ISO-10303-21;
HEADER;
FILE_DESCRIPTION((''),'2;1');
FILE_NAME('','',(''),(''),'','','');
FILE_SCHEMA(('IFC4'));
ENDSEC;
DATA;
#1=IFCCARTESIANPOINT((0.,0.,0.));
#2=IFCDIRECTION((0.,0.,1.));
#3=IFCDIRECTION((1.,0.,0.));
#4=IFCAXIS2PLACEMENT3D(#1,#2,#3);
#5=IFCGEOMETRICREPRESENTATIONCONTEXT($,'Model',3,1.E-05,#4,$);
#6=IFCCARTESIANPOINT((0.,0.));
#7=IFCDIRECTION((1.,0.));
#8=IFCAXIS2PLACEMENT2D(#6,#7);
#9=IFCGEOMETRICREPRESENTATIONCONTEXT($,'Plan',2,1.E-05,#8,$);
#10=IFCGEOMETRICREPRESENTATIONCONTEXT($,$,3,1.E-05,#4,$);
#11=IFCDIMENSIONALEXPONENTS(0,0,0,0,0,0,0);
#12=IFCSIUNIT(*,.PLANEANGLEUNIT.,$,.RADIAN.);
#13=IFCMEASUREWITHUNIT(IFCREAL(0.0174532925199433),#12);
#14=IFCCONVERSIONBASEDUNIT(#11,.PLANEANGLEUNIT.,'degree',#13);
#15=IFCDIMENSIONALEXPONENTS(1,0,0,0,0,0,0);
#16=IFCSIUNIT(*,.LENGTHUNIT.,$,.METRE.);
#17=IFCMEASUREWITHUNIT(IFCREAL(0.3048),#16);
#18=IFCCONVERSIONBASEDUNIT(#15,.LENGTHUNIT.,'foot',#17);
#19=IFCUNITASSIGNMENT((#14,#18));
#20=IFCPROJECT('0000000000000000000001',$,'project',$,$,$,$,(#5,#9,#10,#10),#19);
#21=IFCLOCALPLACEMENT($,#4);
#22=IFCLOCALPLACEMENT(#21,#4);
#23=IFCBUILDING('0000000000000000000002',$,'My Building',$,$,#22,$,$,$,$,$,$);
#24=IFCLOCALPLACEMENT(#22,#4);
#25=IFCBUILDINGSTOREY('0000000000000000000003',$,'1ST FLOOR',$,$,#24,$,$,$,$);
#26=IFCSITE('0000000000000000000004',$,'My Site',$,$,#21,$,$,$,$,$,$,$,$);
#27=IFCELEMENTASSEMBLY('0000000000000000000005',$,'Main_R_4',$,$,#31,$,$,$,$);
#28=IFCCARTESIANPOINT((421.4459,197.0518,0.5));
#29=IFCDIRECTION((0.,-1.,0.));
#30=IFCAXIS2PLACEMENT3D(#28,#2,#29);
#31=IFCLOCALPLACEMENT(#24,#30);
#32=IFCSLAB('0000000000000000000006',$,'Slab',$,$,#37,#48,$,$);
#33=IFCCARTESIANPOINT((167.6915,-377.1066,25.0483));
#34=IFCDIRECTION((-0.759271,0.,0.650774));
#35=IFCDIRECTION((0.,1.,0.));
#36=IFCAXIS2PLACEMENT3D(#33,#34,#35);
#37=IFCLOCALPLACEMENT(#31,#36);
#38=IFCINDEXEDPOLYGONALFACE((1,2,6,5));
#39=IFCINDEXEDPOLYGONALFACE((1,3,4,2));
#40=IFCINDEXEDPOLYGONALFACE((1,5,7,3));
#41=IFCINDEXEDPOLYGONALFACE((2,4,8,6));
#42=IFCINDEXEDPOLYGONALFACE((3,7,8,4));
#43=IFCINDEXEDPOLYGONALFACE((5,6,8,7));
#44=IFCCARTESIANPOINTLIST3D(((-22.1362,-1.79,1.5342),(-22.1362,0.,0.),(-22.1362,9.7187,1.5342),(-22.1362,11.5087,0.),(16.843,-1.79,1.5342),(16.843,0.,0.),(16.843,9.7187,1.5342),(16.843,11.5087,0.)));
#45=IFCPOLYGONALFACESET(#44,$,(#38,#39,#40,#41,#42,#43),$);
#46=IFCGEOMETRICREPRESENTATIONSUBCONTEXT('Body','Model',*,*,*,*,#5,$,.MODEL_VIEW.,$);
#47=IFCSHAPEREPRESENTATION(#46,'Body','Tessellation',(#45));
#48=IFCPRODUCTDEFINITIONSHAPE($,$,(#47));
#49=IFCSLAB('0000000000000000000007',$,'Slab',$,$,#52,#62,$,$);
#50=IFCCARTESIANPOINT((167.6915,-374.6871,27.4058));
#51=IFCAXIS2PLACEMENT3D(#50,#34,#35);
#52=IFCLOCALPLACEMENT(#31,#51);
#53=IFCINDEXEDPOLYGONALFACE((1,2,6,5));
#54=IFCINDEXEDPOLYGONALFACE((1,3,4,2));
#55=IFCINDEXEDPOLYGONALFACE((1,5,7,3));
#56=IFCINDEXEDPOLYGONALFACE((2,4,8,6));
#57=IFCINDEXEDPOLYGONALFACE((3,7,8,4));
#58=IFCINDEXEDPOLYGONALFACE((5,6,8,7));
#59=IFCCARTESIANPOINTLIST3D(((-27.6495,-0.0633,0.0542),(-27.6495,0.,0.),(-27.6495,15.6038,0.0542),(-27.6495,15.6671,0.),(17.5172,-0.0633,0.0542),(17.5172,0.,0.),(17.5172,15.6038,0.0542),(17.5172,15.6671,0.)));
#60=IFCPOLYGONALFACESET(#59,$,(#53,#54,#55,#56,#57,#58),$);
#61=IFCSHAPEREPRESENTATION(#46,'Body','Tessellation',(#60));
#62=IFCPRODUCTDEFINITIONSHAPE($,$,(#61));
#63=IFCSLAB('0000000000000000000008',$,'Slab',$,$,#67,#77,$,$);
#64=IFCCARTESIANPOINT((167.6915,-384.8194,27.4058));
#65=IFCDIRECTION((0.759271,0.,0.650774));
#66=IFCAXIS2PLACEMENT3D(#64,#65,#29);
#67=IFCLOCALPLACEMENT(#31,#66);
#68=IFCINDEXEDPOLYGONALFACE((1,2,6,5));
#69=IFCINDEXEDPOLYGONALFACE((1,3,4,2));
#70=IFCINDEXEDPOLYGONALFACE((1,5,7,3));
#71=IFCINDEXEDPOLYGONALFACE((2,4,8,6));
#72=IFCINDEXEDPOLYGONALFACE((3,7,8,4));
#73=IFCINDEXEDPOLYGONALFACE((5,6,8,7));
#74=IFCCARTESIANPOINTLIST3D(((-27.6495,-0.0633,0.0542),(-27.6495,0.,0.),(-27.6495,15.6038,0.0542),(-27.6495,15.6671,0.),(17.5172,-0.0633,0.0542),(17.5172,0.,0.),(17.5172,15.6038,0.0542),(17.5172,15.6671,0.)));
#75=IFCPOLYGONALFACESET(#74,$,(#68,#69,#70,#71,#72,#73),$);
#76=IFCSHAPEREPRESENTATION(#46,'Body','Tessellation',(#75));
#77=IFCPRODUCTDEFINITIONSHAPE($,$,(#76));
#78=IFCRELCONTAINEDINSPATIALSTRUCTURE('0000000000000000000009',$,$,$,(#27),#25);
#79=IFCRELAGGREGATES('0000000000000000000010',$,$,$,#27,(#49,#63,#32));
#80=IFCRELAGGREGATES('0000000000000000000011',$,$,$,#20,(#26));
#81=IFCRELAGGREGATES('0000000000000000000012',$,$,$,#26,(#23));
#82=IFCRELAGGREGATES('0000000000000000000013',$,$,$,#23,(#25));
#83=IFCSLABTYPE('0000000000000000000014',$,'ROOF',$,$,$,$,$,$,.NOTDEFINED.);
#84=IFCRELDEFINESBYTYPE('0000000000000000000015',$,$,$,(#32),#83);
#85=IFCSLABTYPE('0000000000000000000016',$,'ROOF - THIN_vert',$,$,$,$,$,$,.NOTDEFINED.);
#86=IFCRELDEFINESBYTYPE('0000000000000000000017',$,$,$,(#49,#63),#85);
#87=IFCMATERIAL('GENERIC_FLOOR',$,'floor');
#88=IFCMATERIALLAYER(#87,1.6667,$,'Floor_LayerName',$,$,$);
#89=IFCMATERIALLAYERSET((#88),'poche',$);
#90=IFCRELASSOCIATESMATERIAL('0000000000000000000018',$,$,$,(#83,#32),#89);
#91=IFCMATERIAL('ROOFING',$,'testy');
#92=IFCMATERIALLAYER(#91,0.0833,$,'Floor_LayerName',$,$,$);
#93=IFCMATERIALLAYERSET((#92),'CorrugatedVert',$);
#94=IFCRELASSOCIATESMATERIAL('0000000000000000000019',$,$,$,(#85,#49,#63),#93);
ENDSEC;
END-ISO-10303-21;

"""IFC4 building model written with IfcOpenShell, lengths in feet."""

from ifc_helpers import new_model, entity, si_unit, converted_unit, frame, origin_with_axes, origin_2d_with_axis, place, context, subcontext, project, spatial, line, indexed_curve, outline, extrude, material, layer, layer_set, layer_usage, type_object, element, aggregate, save


model = new_model("IFC4")

# Units and contexts
model_context = context("Model", 3, precision=1e-05, world=origin_with_axes())
plan_context = context("Plan", 2, precision=1e-05, world=origin_2d_with_axis())
context_of_model = context(None, 3, precision=1e-05, world=origin_with_axes())
body_context_1 = subcontext(model_context, "Body", "Model", "MODEL_VIEW")
ifc_project = project(units=[converted_unit("PLANEANGLEUNIT", "degree", entity("IfcReal", 0.0174532925199433), si_unit("PLANEANGLEUNIT", "RADIAN"), dimensions=[0, 0, 0, 0, 0, 0, 0]), converted_unit("LENGTHUNIT", "foot", entity("IfcReal", 0.3048), si_unit("LENGTHUNIT", "METRE"), dimensions=[1, 0, 0, 0, 0, 0, 0])], contexts=[model_context, plan_context, context_of_model, context_of_model])

# Site, building, storey
site_placement = place(None, origin_with_axes())
site = spatial("IfcSite", under=ifc_project, at=site_placement, Name="My Site")
building_placement = place(site_placement, origin_with_axes())
building = spatial("IfcBuilding", under=site, at=building_placement, Name="My Building")
storey_placement = place(building_placement, origin_with_axes())
storey = spatial("IfcBuildingStorey", under=building, at=storey_placement, Name="1ST FLOOR")

# Element assembly, slabs
assembly_placement = place(storey_placement, frame((421.4459, 197.0518, 0.5), z_axis=(0.0, 0.0, 1.0), x_axis=(0.0, -1.0, 0.0)))
assembly = element("IfcElementAssembly", 1, at=assembly_placement, inside=storey, Name="Main_R_4")
ifc_material_1 = material(Name="GENERIC_FLOOR", Category="floor")
ifc_layer_1 = layer(ifc_material_1, 1.6667, Name="Floor_LayerName")
ifc_layer_set_1 = layer_set([ifc_layer_1], Name="poche")
ifc_layer_usage_1 = layer_usage(ifc_layer_set_1, "AXIS3", "POSITIVE", 0.0)
slab_type_1 = type_object("IfcSlabType", Name="ROOF", PredefinedType="NOTDEFINED", material=ifc_layer_set_1)
slab_1_placement = place(assembly_placement, frame((167.6915, -377.1066, 25.0483), z_axis=(-0.759271, 0.0, 0.650774), x_axis=(0.0, 1.0, 0.0)))
slab_1 = element("IfcSlab", 2, at=slab_1_placement, type_object=slab_type_1, material=ifc_layer_usage_1, Name="Slab", context=body_context_1, shape_type="SweptSolid", body=[
    extrude(outline(indexed_curve([(-22.1362, 0.0), (-22.1362, 11.5087), (16.843, 11.5087), (16.843, 0.0)], segments=[line(3, 2), line(2, 1), line(1, 4), line(4, 3)], self_intersect=False)), None, (0.0, -0.759271, 0.650774), 2.3575),
])
ifc_material_2 = material(Name="ROOFING", Category="testy")
ifc_layer_2 = layer(ifc_material_2, 0.0833, Name="Floor_LayerName")
ifc_layer_set_2 = layer_set([ifc_layer_2], Name="CorrugatedVert")
ifc_layer_usage_2 = layer_usage(ifc_layer_set_2, "AXIS3", "POSITIVE", 0.0)
slab_type_2 = type_object("IfcSlabType", Name="ROOF - THIN_vert", PredefinedType="NOTDEFINED", material=ifc_layer_set_2)
slab_2_placement = place(assembly_placement, frame((167.6915, -374.6871, 27.4058), z_axis=(-0.759271, 0.0, 0.650774), x_axis=(0.0, 1.0, 0.0)))
slab_2 = element("IfcSlab", 3, at=slab_2_placement, type_object=slab_type_2, material=ifc_layer_usage_2, Name="Slab", context=body_context_1, shape_type="SweptSolid", body=[
    extrude(outline(indexed_curve([(17.5172, 15.6671), (-27.6495, 15.6671), (-27.6495, 0.0), (17.5172, 0.0)], segments=[line(4, 1), line(1, 2), line(2, 3), line(3, 4)], self_intersect=False)), None, (0.0, -0.759271, 0.650774), 0.0833),
])
ifc_layer_usage_3 = layer_usage(ifc_layer_set_2, "AXIS3", "POSITIVE", 0.0)
slab_3_placement = place(assembly_placement, frame((167.6915, -384.8194, 27.4058), z_axis=(0.759271, 0.0, 0.650774), x_axis=(0.0, -1.0, 0.0)))
slab_3 = element("IfcSlab", 4, at=slab_3_placement, type_object=slab_type_2, material=ifc_layer_usage_3, Name="Slab", context=body_context_1, shape_type="SweptSolid", body=[
    extrude(outline(indexed_curve([(17.5172, 15.6671), (-27.6495, 15.6671), (-27.6495, 0.0), (17.5172, 0.0)], segments=[line(4, 1), line(1, 2), line(2, 3), line(3, 4)], self_intersect=False)), None, (0.0, -0.759271, 0.650774), 0.0833),
])
aggregate(assembly, [slab_2, slab_3, slab_1])

save(model, "model.ifc")
